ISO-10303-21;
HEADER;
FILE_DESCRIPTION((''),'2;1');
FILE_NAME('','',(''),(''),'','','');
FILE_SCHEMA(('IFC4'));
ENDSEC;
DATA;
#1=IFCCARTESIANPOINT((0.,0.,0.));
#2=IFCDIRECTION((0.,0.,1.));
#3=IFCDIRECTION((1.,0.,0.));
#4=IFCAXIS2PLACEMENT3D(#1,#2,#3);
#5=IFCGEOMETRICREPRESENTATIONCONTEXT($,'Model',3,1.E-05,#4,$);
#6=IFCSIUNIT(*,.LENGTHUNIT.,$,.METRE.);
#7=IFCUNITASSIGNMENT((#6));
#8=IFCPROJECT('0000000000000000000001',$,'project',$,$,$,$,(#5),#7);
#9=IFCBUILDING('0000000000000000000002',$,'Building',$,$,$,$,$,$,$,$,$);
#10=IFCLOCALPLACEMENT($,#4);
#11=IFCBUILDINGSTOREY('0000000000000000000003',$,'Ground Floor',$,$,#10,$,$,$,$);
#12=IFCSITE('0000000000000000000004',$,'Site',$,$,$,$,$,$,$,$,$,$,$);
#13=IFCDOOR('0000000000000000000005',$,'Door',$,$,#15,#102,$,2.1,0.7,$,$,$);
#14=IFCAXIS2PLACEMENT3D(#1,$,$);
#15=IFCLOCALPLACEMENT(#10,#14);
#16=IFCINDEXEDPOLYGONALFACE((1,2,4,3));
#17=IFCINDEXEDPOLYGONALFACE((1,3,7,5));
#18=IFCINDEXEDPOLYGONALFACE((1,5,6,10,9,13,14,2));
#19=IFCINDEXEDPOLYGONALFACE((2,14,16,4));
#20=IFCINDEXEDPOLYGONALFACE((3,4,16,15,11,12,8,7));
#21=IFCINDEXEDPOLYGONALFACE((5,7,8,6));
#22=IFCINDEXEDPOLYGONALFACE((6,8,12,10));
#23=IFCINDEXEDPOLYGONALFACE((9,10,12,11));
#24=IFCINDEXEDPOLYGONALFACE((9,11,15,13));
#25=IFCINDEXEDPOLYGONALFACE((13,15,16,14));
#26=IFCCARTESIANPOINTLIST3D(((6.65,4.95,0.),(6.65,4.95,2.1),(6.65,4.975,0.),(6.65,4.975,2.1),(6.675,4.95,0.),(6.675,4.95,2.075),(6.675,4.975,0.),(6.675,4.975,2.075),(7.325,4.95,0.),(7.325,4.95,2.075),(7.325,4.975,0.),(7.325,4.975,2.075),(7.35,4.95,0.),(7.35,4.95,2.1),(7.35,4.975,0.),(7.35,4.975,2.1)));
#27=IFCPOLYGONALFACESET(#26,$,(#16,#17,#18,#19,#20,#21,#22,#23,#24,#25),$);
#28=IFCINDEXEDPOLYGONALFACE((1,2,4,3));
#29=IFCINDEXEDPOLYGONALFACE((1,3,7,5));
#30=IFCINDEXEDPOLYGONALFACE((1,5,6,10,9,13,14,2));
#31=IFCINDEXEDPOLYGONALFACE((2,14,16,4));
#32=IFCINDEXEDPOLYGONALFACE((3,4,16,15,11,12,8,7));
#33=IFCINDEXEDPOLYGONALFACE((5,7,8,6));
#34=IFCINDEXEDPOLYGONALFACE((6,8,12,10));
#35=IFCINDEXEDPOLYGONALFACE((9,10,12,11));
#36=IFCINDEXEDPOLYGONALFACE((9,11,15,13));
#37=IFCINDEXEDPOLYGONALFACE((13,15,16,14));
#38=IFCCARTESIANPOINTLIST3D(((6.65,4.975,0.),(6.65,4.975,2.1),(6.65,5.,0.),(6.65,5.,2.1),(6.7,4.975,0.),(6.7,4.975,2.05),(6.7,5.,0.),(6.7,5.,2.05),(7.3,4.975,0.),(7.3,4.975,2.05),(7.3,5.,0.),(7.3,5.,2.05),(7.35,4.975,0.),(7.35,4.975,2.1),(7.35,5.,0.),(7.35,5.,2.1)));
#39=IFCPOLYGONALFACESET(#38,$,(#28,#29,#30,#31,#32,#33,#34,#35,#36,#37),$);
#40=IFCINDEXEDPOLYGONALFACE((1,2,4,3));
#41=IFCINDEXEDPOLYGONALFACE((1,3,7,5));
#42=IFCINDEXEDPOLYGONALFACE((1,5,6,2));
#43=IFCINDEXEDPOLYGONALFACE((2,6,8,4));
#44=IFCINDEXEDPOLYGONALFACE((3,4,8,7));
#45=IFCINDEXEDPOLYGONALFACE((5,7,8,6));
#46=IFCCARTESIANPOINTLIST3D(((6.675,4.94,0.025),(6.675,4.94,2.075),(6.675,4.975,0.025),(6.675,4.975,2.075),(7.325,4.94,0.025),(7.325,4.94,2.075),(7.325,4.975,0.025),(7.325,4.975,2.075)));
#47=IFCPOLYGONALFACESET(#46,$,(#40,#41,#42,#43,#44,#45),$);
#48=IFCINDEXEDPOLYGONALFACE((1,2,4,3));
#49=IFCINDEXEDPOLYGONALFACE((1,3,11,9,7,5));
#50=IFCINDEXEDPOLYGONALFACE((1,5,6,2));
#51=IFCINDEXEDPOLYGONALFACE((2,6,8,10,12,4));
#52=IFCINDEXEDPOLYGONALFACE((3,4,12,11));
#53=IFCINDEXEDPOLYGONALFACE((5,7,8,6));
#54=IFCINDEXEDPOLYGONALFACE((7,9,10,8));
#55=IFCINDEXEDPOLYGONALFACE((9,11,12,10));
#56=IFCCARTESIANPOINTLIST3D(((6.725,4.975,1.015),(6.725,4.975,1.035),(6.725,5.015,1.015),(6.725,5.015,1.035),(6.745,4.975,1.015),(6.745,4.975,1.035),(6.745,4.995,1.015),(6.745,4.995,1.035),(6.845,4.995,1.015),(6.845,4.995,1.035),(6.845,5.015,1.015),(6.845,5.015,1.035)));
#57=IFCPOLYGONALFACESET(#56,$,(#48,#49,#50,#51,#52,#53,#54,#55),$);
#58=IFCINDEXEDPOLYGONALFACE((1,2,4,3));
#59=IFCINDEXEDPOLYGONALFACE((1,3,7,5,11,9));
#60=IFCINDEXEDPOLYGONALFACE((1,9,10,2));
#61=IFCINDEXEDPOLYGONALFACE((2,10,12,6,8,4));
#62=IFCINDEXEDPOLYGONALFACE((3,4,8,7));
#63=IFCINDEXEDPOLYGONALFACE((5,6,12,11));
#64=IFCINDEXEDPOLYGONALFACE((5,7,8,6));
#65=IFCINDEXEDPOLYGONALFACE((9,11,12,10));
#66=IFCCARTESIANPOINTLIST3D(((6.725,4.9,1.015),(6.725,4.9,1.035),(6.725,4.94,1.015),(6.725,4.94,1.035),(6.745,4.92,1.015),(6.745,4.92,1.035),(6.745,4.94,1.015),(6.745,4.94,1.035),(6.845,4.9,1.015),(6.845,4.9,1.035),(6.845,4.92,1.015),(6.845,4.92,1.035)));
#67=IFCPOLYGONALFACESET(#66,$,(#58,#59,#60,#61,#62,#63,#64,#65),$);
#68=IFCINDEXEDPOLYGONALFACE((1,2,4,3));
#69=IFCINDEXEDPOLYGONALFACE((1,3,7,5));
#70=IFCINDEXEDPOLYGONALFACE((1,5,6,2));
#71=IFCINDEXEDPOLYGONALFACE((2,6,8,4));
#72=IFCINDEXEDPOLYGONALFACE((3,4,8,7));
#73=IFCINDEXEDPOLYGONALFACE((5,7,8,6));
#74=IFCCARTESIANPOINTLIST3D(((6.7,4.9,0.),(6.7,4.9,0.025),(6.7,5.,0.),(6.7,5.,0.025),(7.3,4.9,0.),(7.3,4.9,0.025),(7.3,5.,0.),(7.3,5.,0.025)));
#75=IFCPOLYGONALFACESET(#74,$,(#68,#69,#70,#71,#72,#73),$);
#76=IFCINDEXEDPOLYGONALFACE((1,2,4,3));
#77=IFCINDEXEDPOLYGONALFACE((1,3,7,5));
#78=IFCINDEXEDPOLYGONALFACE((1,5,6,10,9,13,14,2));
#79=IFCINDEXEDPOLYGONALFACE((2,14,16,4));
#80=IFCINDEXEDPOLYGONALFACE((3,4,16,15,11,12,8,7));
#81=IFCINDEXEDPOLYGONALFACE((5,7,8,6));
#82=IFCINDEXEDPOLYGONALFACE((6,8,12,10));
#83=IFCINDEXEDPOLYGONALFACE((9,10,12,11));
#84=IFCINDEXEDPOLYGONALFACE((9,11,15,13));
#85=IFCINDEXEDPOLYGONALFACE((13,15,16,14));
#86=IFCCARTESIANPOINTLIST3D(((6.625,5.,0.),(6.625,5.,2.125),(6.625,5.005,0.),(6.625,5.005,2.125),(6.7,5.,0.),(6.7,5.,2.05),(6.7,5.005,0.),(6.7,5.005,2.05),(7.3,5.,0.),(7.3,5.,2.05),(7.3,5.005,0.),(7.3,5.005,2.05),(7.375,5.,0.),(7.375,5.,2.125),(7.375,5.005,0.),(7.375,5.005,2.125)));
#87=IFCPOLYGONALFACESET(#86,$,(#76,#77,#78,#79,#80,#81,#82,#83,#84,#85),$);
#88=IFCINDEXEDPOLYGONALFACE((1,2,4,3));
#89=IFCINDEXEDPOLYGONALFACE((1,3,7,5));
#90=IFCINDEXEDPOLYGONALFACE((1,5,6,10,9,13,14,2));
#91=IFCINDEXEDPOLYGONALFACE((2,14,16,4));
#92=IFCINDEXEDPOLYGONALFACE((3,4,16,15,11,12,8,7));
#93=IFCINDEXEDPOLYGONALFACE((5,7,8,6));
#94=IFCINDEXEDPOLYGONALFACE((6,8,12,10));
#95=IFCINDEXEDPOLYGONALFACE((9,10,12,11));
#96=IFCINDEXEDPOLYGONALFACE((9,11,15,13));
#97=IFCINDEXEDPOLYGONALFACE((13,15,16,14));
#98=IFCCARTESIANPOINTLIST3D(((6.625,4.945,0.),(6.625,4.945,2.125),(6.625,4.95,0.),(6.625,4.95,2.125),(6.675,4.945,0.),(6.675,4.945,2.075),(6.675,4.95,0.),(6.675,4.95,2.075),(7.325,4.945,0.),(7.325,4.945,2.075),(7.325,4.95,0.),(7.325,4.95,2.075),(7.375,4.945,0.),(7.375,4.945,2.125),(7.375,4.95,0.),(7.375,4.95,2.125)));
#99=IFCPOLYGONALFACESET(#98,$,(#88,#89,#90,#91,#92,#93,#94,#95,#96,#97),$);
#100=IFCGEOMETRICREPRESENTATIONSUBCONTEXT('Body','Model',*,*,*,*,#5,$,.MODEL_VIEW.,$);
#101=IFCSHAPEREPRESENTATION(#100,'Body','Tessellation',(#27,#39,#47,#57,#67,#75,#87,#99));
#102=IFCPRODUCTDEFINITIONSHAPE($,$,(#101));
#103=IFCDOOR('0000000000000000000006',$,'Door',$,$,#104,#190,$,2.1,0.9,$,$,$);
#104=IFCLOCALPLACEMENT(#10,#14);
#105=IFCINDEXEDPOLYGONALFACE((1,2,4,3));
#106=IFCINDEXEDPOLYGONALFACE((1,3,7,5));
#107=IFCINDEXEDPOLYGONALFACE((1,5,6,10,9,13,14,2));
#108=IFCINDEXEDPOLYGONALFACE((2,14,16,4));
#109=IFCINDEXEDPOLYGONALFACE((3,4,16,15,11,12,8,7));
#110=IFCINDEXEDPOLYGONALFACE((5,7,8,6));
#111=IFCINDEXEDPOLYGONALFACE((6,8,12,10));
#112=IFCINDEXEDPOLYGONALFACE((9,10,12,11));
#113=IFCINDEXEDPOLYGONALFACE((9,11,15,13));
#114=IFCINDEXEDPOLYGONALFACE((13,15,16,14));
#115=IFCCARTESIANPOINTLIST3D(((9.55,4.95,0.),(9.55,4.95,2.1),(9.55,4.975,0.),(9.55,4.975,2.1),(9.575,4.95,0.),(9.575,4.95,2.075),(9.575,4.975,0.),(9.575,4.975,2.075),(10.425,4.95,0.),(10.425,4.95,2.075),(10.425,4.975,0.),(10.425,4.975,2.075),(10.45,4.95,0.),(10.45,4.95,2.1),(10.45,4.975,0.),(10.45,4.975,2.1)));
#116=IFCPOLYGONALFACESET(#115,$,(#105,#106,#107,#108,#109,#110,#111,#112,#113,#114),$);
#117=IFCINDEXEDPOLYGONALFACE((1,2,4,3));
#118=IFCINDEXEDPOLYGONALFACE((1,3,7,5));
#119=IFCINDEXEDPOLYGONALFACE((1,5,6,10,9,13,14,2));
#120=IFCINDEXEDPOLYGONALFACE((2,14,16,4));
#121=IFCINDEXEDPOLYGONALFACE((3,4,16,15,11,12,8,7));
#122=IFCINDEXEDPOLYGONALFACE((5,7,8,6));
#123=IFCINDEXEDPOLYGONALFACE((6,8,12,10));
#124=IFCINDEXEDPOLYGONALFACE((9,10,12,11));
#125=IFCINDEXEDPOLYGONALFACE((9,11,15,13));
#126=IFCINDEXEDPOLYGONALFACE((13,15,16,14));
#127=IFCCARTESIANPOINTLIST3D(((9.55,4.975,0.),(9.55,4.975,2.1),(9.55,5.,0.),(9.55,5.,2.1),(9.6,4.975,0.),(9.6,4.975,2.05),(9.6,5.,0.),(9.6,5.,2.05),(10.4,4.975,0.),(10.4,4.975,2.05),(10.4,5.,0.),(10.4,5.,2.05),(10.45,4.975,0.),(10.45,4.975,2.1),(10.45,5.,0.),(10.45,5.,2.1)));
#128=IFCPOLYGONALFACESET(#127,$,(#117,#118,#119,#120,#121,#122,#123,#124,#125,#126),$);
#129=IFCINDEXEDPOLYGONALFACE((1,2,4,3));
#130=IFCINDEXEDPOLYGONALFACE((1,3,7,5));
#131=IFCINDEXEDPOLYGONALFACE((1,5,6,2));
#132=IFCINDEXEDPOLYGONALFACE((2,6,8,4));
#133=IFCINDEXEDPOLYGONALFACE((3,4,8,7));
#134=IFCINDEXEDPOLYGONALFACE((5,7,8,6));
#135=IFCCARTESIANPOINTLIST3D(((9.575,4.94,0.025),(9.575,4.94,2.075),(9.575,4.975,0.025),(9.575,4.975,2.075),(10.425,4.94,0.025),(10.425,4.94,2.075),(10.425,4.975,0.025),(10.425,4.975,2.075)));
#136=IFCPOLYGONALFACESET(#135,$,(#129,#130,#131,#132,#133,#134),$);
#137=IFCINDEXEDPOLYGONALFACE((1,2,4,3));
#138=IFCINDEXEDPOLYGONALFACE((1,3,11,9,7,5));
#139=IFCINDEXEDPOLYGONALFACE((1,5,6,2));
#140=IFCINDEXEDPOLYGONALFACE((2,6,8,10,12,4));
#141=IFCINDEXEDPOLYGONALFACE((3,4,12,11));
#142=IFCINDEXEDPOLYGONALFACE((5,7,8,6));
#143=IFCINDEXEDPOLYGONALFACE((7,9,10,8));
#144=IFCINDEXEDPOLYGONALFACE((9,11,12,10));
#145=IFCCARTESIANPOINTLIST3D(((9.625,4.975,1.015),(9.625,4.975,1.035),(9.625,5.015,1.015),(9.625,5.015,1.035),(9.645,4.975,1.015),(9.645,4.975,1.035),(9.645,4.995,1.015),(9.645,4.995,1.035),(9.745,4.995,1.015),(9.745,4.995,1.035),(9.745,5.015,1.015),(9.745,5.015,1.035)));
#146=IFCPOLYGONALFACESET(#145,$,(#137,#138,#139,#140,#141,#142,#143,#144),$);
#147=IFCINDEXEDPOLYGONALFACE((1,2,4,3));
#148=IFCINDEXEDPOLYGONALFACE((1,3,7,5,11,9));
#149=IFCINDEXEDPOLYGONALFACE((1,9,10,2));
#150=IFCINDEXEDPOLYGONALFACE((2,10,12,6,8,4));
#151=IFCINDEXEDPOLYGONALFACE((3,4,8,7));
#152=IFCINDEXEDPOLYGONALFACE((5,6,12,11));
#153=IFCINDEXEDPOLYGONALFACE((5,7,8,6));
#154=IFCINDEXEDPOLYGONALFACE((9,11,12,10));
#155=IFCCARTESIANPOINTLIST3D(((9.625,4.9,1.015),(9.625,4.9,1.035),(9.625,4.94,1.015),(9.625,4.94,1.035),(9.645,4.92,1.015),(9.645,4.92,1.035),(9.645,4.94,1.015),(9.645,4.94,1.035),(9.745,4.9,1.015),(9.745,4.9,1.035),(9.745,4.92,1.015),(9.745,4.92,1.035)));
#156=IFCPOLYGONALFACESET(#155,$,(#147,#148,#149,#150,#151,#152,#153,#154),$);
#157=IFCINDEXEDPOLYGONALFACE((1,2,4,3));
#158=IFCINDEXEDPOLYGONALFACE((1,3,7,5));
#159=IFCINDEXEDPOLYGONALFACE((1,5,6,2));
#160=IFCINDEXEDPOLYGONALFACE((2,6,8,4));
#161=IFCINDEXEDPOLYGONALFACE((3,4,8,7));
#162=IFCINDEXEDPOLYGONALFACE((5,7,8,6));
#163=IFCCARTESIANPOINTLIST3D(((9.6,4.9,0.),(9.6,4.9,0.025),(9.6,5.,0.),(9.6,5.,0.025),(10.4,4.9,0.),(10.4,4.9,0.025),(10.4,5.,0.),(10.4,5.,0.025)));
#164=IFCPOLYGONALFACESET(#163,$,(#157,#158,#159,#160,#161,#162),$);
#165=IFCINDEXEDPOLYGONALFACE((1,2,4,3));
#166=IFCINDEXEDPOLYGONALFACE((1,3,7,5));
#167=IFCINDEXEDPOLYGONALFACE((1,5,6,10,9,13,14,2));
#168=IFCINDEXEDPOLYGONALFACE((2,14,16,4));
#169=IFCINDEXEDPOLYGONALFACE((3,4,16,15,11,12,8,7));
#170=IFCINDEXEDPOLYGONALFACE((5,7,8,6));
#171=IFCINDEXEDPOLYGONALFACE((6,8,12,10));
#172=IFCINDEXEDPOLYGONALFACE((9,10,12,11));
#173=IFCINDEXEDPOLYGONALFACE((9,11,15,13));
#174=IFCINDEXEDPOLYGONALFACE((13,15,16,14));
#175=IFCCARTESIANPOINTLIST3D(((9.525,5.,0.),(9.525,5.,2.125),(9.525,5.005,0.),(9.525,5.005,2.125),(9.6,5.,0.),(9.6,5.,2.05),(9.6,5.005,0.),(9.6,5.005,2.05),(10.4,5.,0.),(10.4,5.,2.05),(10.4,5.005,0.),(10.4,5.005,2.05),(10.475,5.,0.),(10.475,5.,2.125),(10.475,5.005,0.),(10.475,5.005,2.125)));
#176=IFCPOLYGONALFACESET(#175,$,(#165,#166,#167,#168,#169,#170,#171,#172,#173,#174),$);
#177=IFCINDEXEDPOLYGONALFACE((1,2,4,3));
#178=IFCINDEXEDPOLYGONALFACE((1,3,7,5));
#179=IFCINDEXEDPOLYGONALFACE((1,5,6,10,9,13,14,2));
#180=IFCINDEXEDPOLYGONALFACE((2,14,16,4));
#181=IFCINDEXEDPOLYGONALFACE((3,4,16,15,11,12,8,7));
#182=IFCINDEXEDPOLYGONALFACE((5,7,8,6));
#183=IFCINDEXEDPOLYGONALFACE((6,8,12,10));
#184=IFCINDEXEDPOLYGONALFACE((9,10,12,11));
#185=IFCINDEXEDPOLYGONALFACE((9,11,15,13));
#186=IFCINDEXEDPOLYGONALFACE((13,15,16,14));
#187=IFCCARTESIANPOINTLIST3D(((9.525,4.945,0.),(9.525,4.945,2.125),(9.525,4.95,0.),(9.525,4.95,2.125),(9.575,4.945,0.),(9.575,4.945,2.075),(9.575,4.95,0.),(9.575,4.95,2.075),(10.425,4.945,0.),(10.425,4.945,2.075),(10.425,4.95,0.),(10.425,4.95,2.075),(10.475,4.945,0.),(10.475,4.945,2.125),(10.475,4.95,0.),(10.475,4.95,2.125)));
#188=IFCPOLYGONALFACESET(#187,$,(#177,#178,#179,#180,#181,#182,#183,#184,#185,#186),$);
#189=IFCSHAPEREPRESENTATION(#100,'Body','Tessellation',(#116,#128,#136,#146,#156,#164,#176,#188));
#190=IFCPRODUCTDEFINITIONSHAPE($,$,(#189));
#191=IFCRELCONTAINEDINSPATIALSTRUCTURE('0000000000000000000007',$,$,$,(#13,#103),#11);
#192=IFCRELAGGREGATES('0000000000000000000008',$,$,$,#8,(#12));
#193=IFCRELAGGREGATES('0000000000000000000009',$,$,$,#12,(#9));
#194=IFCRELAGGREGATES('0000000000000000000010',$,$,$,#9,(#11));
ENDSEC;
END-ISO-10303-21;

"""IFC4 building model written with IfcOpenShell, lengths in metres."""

from ifc_helpers import new_model, si_unit, frame, origin_with_axes, place, context, subcontext, project, spatial, line, indexed_curve, outline, extrude, element, save


model = new_model("IFC4")

# Units and contexts
model_context = context("Model", 3, precision=1e-05, world=origin_with_axes())
body_context = subcontext(model_context, "Body", "Model", "MODEL_VIEW")
ifc_project = project(units=[si_unit("LENGTHUNIT", "METRE")], contexts=[model_context])

# Site, building, storey
site = spatial("IfcSite", under=ifc_project, Name="Site")
building = spatial("IfcBuilding", under=site, Name="Building")
storey_placement = place(None, origin_with_axes())
storey = spatial("IfcBuildingStorey", under=building, at=storey_placement, Name="Ground Floor")

# Doors
door_1_placement = place(storey_placement, frame((7.35, 5.0, 0.0), z_axis=(0.0, 0.0, 1.0), x_axis=(-1.0, 0.0, 0.0)))
element("IfcDoor", 1, at=door_1_placement, inside=storey, Name="Door", OverallHeight=2.1, OverallWidth=0.7, context=body_context, shape_type="SweptSolid", body=[
    extrude(outline(indexed_curve([(0.0, 0.0), (0.0, 2.1), (0.7, 2.1), (0.7, 0.0), (0.675, 0.0), (0.675, 2.075), (0.025, 2.075), (0.025, 0.0)], segments=[line(1, 2, 3, 4, 5, 6, 7, 8, 1)])), frame((0.0, 0.025, 0.0), z_axis=(0.0, -1.0, 0.0), x_axis=(1.0, 0.0, 0.0)), (0.0, 0.0, -1.0), 0.025),
    extrude(outline(indexed_curve([(0.0, 0.0), (0.0, 2.1), (0.7, 2.1), (0.7, 0.0), (0.65, 0.0), (0.65, 2.05), (0.05, 2.05), (0.05, 0.0)], segments=[line(1, 2, 3, 4, 5, 6, 7, 8, 1)])), frame((0.0, 0.0, 0.0), z_axis=(0.0, -1.0, 0.0), x_axis=(1.0, 0.0, 0.0)), (0.0, 0.0, -1.0), 0.025),
    extrude(outline(indexed_curve([(0.0, 0.0), (0.65, 0.0), (0.65, 0.035), (0.0, 0.035)], segments=[line(1, 2, 3, 4, 1)])), frame((0.025, 0.025, 0.025), z_axis=(0.0, 0.0, 1.0), x_axis=(1.0, 0.0, 0.0)), (0.0, 0.0, 1.0), 2.05),
    extrude(outline(indexed_curve([(0.0, 0.0), (0.0, -0.04), (-0.12, -0.04), (-0.12, -0.02), (-0.02, -0.02), (-0.02, 0.0)], segments=[line(1, 2, 3, 4, 5, 6, 1)])), frame((0.625, 0.025, 1.015), z_axis=(0.0, 0.0, 1.0), x_axis=(1.0, 0.0, 0.0)), (0.0, 0.0, 1.0), 0.02),
    extrude(outline(indexed_curve([(0.0, 0.0), (0.0, 0.04), (-0.12, 0.04), (-0.12, 0.02), (-0.02, 0.02), (-0.02, 0.0)], segments=[line(1, 2, 3, 4, 5, 6, 1)])), frame((0.625, 0.06, 1.015), z_axis=(0.0, 0.0, 1.0), x_axis=(1.0, 0.0, 0.0)), (0.0, 0.0, 1.0), 0.02),
    extrude(outline(indexed_curve([(0.0, 0.0), (0.6, 0.0), (0.6, 0.1), (0.0, 0.1)], segments=[line(1, 2, 3, 4, 1)])), frame((0.05, 0.0, 0.0), z_axis=(0.0, 0.0, 1.0), x_axis=(1.0, 0.0, 0.0)), (0.0, 0.0, 1.0), 0.025),
    extrude(outline(indexed_curve([(0.0, 0.0), (0.0, 2.125), (0.75, 2.125), (0.75, 0.0), (0.675, 0.0), (0.675, 2.05), (0.075, 2.05), (0.075, 0.0)], segments=[line(1, 2, 3, 4, 5, 6, 7, 8, 1)])), frame((-0.025, -0.005, 0.0), z_axis=(0.0, -1.0, 0.0), x_axis=(1.0, 0.0, 0.0)), (0.0, 0.0, -1.0), 0.005),
    extrude(outline(indexed_curve([(0.0, 0.0), (0.0, 2.125), (0.75, 2.125), (0.75, 0.0), (0.7, 0.0), (0.7, 2.075), (0.05, 2.075), (0.05, 0.0)], segments=[line(1, 2, 3, 4, 5, 6, 7, 8, 1)])), frame((-0.025, 0.05, 0.0), z_axis=(0.0, -1.0, 0.0), x_axis=(1.0, 0.0, 0.0)), (0.0, 0.0, -1.0), 0.005),
])
door_2_placement = place(storey_placement, frame((10.45, 5.0, 0.0), z_axis=(0.0, 0.0, 1.0), x_axis=(-1.0, 0.0, 0.0)))
element("IfcDoor", 2, at=door_2_placement, inside=storey, Name="Door", OverallHeight=2.1, OverallWidth=0.9, context=body_context, shape_type="SweptSolid", body=[
    extrude(outline(indexed_curve([(0.0, 0.0), (0.0, 2.1), (0.9, 2.1), (0.9, 0.0), (0.875, 0.0), (0.875, 2.075), (0.025, 2.075), (0.025, 0.0)], segments=[line(1, 2, 3, 4, 5, 6, 7, 8, 1)])), frame((0.0, 0.025, 0.0), z_axis=(0.0, -1.0, 0.0), x_axis=(1.0, 0.0, 0.0)), (0.0, 0.0, -1.0), 0.025),
    extrude(outline(indexed_curve([(0.0, 0.0), (0.0, 2.1), (0.9, 2.1), (0.9, 0.0), (0.85, 0.0), (0.85, 2.05), (0.05, 2.05), (0.05, 0.0)], segments=[line(1, 2, 3, 4, 5, 6, 7, 8, 1)])), frame((0.0, 0.0, 0.0), z_axis=(0.0, -1.0, 0.0), x_axis=(1.0, 0.0, 0.0)), (0.0, 0.0, -1.0), 0.025),
    extrude(outline(indexed_curve([(0.0, 0.0), (0.85, 0.0), (0.85, 0.035), (0.0, 0.035)], segments=[line(1, 2, 3, 4, 1)])), frame((0.025, 0.025, 0.025), z_axis=(0.0, 0.0, 1.0), x_axis=(1.0, 0.0, 0.0)), (0.0, 0.0, 1.0), 2.05),
    extrude(outline(indexed_curve([(0.0, 0.0), (0.0, -0.04), (-0.12, -0.04), (-0.12, -0.02), (-0.02, -0.02), (-0.02, 0.0)], segments=[line(1, 2, 3, 4, 5, 6, 1)])), frame((0.825, 0.025, 1.015), z_axis=(0.0, 0.0, 1.0), x_axis=(1.0, 0.0, 0.0)), (0.0, 0.0, 1.0), 0.02),
    extrude(outline(indexed_curve([(0.0, 0.0), (0.0, 0.04), (-0.12, 0.04), (-0.12, 0.02), (-0.02, 0.02), (-0.02, 0.0)], segments=[line(1, 2, 3, 4, 5, 6, 1)])), frame((0.825, 0.06, 1.015), z_axis=(0.0, 0.0, 1.0), x_axis=(1.0, 0.0, 0.0)), (0.0, 0.0, 1.0), 0.02),
    extrude(outline(indexed_curve([(0.0, 0.0), (0.8, 0.0), (0.8, 0.1), (0.0, 0.1)], segments=[line(1, 2, 3, 4, 1)])), frame((0.05, 0.0, 0.0), z_axis=(0.0, 0.0, 1.0), x_axis=(1.0, 0.0, 0.0)), (0.0, 0.0, 1.0), 0.025),
    extrude(outline(indexed_curve([(0.0, 0.0), (0.0, 2.125), (0.95, 2.125), (0.95, 0.0), (0.875, 0.0), (0.875, 2.05), (0.075, 2.05), (0.075, 0.0)], segments=[line(1, 2, 3, 4, 5, 6, 7, 8, 1)])), frame((-0.025, -0.005, 0.0), z_axis=(0.0, -1.0, 0.0), x_axis=(1.0, 0.0, 0.0)), (0.0, 0.0, -1.0), 0.005),
    extrude(outline(indexed_curve([(0.0, 0.0), (0.0, 2.125), (0.95, 2.125), (0.95, 0.0), (0.9, 0.0), (0.9, 2.075), (0.05, 2.075), (0.05, 0.0)], segments=[line(1, 2, 3, 4, 5, 6, 7, 8, 1)])), frame((-0.025, 0.05, 0.0), z_axis=(0.0, -1.0, 0.0), x_axis=(1.0, 0.0, 0.0)), (0.0, 0.0, -1.0), 0.005),
])

save(model, "model.ifc")
